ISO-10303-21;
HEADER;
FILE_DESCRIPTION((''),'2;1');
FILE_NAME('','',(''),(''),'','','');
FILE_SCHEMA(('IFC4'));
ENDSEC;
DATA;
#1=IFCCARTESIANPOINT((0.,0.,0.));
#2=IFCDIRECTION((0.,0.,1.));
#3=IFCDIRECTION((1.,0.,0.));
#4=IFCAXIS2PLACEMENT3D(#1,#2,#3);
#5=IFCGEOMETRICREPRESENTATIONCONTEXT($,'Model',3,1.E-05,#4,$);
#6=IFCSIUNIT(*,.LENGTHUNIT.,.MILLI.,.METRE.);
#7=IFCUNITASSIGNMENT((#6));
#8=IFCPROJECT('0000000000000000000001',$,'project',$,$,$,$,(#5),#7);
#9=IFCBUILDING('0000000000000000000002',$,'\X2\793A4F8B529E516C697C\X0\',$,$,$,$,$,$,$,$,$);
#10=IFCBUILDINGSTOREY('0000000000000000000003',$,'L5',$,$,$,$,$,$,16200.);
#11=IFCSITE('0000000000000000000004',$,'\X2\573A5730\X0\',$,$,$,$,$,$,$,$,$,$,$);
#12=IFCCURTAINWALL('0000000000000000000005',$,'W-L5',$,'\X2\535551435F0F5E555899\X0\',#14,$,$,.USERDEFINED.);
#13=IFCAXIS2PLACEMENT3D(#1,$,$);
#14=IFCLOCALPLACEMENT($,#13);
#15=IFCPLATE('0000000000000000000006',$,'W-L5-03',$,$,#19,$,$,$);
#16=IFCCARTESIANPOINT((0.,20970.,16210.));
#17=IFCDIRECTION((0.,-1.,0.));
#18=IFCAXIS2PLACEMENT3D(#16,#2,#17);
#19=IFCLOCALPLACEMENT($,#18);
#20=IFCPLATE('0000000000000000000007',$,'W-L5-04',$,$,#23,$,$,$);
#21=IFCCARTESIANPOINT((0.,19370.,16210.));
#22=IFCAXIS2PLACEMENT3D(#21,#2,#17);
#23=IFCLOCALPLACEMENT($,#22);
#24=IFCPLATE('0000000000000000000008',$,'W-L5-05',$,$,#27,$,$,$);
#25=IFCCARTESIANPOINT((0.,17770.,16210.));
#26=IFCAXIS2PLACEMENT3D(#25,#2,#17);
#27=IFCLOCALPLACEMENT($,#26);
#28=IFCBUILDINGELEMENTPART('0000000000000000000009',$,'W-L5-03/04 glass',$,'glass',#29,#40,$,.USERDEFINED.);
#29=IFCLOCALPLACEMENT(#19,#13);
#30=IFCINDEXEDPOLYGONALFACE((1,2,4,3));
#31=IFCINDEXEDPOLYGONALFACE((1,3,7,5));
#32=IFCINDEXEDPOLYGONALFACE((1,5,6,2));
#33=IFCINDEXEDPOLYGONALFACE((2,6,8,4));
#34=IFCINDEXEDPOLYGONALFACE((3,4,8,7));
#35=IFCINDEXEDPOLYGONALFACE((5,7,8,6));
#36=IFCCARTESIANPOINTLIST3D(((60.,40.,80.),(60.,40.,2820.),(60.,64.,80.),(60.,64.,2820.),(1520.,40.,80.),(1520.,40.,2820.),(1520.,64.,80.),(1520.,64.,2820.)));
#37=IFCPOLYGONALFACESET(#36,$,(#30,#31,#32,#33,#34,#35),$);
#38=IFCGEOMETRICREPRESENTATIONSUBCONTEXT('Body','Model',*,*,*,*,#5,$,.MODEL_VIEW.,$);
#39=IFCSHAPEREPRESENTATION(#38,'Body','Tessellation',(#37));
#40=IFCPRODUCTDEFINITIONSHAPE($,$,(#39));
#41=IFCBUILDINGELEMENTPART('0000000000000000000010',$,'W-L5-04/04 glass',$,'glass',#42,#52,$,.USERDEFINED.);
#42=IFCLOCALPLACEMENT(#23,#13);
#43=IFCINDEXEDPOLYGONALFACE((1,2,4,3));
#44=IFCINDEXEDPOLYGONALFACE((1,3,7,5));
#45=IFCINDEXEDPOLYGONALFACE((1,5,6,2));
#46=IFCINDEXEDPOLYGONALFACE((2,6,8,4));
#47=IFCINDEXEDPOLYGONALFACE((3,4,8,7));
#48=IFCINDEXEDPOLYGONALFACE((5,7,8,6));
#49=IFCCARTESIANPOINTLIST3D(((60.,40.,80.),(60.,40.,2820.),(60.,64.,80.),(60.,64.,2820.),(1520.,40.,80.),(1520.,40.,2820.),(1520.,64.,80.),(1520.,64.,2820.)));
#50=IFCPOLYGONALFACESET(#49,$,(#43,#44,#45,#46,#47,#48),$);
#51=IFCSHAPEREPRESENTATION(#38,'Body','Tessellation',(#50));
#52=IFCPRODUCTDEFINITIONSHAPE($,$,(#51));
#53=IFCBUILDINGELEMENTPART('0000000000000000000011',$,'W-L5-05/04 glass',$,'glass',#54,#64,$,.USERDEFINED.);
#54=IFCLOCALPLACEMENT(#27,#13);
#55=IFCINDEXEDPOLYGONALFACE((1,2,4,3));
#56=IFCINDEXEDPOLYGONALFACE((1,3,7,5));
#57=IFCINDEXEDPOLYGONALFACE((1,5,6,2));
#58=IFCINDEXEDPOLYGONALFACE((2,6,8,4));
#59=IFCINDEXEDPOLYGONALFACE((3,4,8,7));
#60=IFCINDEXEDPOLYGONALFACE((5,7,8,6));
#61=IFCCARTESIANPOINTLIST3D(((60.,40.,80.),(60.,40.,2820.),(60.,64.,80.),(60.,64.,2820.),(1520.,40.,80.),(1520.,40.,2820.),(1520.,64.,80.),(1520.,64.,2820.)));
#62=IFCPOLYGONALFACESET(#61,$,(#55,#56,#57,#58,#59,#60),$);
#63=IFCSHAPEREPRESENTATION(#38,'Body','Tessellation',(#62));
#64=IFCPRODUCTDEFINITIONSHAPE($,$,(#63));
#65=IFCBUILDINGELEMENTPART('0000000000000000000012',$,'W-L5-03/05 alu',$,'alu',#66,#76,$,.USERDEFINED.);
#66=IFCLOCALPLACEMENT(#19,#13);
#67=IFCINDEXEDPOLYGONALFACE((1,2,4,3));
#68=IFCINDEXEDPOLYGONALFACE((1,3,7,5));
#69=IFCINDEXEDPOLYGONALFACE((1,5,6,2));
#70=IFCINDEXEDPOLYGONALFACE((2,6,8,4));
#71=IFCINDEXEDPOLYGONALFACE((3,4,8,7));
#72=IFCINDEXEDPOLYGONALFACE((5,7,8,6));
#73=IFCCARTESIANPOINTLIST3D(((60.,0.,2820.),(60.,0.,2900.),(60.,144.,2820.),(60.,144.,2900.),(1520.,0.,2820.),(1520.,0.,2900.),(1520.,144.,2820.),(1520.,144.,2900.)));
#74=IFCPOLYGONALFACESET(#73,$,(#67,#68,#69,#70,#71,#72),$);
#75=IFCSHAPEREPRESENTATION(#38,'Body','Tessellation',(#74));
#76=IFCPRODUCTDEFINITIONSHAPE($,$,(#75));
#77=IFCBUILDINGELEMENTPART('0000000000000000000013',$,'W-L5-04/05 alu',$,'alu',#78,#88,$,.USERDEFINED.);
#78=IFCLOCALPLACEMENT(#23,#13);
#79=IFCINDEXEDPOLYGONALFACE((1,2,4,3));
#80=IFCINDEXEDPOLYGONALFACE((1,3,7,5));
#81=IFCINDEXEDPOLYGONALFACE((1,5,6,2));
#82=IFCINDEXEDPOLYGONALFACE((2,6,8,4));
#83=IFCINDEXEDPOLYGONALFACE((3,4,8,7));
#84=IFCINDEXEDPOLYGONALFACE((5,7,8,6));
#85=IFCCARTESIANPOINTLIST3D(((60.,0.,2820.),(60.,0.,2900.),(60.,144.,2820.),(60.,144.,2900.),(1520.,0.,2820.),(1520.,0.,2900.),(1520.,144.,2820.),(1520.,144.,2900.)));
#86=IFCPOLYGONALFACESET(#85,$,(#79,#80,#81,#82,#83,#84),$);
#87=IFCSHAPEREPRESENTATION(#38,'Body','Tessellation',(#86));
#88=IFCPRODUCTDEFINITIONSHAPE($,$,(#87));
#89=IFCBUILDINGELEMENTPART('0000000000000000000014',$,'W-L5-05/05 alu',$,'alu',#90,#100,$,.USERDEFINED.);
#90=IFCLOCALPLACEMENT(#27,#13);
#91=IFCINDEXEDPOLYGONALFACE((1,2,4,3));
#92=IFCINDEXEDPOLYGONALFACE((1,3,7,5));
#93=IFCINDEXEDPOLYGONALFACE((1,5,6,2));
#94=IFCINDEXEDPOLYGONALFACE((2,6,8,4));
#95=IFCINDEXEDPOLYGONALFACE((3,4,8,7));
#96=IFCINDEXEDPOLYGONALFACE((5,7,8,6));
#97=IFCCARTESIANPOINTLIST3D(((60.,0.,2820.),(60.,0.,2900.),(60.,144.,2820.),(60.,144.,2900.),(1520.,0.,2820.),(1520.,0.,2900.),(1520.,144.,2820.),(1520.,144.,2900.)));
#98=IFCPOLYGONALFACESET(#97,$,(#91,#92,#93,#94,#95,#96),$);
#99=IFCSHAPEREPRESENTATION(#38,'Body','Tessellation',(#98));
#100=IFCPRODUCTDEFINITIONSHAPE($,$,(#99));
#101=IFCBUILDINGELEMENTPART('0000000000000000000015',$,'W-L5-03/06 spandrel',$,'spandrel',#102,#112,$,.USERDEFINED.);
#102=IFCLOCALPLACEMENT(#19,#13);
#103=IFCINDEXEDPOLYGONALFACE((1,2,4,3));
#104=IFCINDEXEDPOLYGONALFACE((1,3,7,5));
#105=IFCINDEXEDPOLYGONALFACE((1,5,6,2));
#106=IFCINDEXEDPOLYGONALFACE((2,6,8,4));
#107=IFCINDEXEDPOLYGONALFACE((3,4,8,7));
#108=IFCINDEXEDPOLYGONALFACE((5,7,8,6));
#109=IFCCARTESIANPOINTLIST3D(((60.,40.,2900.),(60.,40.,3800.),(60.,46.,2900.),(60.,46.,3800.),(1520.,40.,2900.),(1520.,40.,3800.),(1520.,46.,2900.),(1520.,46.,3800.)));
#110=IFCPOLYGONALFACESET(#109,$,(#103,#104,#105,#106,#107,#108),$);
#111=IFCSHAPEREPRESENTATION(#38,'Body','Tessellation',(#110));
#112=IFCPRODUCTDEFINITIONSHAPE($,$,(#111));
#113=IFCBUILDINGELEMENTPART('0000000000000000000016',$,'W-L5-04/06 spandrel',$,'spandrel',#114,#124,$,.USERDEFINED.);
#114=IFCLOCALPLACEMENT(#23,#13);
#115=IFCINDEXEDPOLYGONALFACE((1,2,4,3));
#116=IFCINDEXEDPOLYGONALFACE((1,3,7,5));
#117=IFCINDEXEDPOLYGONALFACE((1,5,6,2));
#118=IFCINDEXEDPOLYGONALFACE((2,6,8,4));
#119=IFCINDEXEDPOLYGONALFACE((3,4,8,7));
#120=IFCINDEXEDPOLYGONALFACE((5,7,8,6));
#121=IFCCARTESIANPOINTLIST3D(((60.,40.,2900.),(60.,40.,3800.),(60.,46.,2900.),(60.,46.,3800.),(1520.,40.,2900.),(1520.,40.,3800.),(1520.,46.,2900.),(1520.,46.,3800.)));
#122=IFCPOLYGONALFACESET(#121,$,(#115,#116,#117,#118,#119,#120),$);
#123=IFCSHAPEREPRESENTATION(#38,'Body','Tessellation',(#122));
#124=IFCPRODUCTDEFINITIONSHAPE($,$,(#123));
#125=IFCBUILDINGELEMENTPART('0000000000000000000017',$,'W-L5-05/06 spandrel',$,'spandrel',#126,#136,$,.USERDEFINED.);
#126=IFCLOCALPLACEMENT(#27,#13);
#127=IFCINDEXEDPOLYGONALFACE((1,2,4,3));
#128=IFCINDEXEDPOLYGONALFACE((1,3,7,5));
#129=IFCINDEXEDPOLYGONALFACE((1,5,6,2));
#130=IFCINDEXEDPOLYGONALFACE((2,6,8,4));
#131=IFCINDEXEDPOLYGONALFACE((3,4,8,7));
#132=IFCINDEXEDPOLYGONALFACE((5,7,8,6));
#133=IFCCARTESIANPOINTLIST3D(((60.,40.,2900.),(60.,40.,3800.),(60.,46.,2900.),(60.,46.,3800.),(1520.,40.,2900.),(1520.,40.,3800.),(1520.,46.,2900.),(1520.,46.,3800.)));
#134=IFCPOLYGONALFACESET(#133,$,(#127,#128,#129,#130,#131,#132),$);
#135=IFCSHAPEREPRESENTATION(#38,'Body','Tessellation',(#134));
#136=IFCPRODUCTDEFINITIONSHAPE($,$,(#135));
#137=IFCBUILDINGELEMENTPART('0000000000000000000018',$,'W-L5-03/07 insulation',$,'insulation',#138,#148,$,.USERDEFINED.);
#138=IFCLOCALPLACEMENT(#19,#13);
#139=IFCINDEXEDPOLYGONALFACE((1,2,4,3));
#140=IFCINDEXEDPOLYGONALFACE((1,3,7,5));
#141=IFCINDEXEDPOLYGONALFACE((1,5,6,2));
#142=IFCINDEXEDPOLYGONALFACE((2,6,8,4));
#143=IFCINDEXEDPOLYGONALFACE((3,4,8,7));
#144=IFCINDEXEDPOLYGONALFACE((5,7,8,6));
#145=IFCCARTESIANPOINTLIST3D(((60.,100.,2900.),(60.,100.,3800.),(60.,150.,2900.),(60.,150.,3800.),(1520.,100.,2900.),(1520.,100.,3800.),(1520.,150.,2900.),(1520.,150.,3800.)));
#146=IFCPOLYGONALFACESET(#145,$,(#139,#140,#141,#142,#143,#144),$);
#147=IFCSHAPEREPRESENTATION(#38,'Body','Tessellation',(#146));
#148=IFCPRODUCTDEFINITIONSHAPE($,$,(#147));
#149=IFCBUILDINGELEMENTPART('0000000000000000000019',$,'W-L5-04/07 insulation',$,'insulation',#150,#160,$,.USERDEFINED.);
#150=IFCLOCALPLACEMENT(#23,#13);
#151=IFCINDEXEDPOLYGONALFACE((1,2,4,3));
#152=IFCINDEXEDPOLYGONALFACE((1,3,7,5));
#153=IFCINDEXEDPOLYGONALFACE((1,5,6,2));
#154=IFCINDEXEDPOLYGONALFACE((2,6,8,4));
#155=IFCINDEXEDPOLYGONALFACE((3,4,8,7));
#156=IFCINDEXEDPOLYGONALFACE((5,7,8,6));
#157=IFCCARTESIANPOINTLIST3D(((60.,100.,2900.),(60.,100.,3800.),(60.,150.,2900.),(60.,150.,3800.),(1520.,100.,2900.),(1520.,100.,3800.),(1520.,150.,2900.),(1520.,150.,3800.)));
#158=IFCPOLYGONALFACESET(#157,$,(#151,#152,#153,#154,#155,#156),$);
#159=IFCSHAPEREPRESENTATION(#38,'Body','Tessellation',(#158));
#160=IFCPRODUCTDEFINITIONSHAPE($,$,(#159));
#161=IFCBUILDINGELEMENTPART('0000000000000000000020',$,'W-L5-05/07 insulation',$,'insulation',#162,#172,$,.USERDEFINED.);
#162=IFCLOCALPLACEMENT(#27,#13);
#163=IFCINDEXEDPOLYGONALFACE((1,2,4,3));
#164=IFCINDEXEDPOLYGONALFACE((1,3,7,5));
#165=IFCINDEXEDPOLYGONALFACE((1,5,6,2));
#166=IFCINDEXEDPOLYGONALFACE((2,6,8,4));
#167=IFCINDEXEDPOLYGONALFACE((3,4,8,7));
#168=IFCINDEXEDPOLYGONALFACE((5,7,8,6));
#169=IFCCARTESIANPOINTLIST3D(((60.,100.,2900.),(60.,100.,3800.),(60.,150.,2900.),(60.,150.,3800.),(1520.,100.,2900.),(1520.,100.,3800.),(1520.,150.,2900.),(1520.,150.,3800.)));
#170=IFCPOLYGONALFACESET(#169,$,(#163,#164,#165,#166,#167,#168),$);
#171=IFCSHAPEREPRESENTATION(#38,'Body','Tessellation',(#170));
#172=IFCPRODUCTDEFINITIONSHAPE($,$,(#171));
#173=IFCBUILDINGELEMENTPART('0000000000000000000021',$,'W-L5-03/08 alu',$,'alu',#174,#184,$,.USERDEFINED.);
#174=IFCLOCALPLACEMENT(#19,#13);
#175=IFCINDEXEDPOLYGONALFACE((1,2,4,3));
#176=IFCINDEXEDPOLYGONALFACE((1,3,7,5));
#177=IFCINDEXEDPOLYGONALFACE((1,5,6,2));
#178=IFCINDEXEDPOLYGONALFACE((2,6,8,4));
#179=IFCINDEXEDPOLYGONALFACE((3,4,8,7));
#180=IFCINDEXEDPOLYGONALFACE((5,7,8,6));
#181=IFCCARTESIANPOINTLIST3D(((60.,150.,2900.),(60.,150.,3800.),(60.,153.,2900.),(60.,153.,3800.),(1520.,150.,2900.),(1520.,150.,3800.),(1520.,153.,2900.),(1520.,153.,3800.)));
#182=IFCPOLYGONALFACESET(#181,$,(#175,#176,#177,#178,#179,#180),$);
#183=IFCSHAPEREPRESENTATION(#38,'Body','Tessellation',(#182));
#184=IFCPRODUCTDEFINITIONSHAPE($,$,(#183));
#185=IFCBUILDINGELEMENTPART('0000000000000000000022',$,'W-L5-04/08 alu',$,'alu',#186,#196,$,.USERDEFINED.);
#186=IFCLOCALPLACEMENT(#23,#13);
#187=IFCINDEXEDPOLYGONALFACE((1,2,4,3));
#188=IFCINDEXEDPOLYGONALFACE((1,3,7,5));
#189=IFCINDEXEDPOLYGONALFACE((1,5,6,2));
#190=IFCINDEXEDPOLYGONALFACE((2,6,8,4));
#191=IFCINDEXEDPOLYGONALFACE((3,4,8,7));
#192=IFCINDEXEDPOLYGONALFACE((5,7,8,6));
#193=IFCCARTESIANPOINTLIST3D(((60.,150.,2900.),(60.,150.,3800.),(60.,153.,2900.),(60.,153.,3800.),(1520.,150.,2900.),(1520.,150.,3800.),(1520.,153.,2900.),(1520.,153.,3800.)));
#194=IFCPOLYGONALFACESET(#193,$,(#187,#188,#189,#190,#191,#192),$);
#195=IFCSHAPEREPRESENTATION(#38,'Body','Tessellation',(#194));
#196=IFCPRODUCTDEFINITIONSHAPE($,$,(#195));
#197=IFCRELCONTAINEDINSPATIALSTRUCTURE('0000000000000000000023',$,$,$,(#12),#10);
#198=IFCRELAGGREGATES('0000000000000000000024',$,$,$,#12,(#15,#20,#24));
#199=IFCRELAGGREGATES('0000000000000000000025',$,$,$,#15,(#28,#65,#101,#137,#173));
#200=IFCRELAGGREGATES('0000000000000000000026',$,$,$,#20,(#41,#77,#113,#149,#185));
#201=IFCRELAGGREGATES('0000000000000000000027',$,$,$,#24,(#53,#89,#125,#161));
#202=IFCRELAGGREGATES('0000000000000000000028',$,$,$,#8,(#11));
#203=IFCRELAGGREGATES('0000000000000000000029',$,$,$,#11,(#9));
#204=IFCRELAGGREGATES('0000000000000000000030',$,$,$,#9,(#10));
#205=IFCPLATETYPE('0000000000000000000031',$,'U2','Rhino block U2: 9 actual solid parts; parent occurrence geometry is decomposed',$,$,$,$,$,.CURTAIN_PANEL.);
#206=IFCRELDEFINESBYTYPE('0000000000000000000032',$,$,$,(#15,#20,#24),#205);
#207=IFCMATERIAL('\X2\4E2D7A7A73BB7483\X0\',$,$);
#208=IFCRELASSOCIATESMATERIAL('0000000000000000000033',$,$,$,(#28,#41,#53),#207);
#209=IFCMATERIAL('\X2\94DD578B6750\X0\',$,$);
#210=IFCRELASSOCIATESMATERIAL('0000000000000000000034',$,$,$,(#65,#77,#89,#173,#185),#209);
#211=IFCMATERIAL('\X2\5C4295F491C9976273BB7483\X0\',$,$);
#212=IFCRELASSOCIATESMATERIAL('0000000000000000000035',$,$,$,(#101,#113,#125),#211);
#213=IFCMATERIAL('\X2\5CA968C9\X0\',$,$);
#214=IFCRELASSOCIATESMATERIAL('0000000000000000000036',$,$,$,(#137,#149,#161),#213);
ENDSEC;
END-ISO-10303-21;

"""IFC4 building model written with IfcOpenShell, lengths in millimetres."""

from ifc_helpers import new_model, si_unit, frame, frame_2d, origin, origin_with_axes, place, context, subcontext, project, spatial, rectangle, extrude, source, transform, mapped, material, type_object, element, aggregate, save


model = new_model("IFC4")

# Units and contexts
model_context = context("Model", 3, precision=1e-05, world=origin_with_axes())
body_context = subcontext(model_context, "Body", "Model", "MODEL_VIEW")
ifc_project = project(units=[si_unit("LENGTHUNIT", "METRE", prefix="MILLI")], contexts=[model_context])

# Site, building, storey
site = spatial("IfcSite", under=ifc_project, Name="场地")
building = spatial("IfcBuilding", under=site, Name="示例办公楼")
storey = spatial("IfcBuildingStorey", under=building, Name="L5", Elevation=16200.0)

# Curtain wall, plates, building element parts
curtain_wall = element("IfcCurtainWall", 1, inside=storey, Name="W-L5", ObjectType="单元式幕墙", PredefinedType="USERDEFINED")
plate_type = type_object("IfcPlateType", Name="U2", Description="Rhino block U2: 9 actual solid parts; parent occurrence geometry is decomposed", PredefinedType="CURTAIN_PANEL")
plate_1_placement = place(None, frame((0.0, 20970.0, 16210.0), z_axis=(0.0, 0.0, 1.0), x_axis=(0.0, -1.0, 0.0)))
plate_1 = element("IfcPlate", 2, at=plate_1_placement, type_object=plate_type, Name="W-L5-03")
ifc_material_1 = material(Name="铝型材")
plate_2_placement = place(None, frame((0.0, 19370.0, 16210.0), z_axis=(0.0, 0.0, 1.0), x_axis=(0.0, -1.0, 0.0)))
plate_2 = element("IfcPlate", 3, at=plate_2_placement, type_object=plate_type, Name="W-L5-04")
plate_3_placement = place(None, frame((0.0, 17770.0, 16210.0), z_axis=(0.0, 0.0, 1.0), x_axis=(0.0, -1.0, 0.0)))
plate_3 = element("IfcPlate", 4, at=plate_3_placement, type_object=plate_type, Name="W-L5-05")
aggregate(curtain_wall, [plate_1, plate_2, plate_3])
ifc_material_2 = material(Name="中空玻璃")
shared_shape_1 = source(origin(), body_context, "Body", "SweptSolid", [
    extrude(rectangle(XDim=1460.0, YDim=24.0, at=frame_2d((790.0, 52.0))), frame((0.0, 0.0, 80.0)), (0.0, 0.0, 1.0), 2740.0),
])
building_element_part_1_placement = place(plate_1_placement, origin())
building_element_part_1 = element("IfcBuildingElementPart", 5, at=building_element_part_1_placement, material=ifc_material_2, Name="W-L5-03/04 glass", ObjectType="glass", PredefinedType="USERDEFINED", context=body_context, shape_type="MappedRepresentation", body=[
    mapped(shared_shape_1, transform((0.0, 0.0, 0.0))),
])
building_element_part_2_placement = place(plate_2_placement, origin())
building_element_part_2 = element("IfcBuildingElementPart", 6, at=building_element_part_2_placement, material=ifc_material_2, Name="W-L5-04/04 glass", ObjectType="glass", PredefinedType="USERDEFINED", context=body_context, shape_type="MappedRepresentation", body=[
    mapped(shared_shape_1, transform((0.0, 0.0, 0.0))),
])
building_element_part_3_placement = place(plate_3_placement, origin())
building_element_part_3 = element("IfcBuildingElementPart", 7, at=building_element_part_3_placement, material=ifc_material_2, Name="W-L5-05/04 glass", ObjectType="glass", PredefinedType="USERDEFINED", context=body_context, shape_type="MappedRepresentation", body=[
    mapped(shared_shape_1, transform((0.0, 0.0, 0.0))),
])
shared_shape_2 = source(origin(), body_context, "Body", "SweptSolid", [
    extrude(rectangle(XDim=1460.0, YDim=144.0, at=frame_2d((790.0, 72.0))), frame((0.0, 0.0, 2820.0)), (0.0, 0.0, 1.0), 80.0),
])
building_element_part_4_placement = place(plate_1_placement, origin())
building_element_part_4 = element("IfcBuildingElementPart", 8, at=building_element_part_4_placement, material=ifc_material_1, Name="W-L5-03/05 alu", ObjectType="alu", PredefinedType="USERDEFINED", context=body_context, shape_type="MappedRepresentation", body=[
    mapped(shared_shape_2, transform((0.0, 0.0, 0.0))),
])
building_element_part_5_placement = place(plate_2_placement, origin())
building_element_part_5 = element("IfcBuildingElementPart", 9, at=building_element_part_5_placement, material=ifc_material_1, Name="W-L5-04/05 alu", ObjectType="alu", PredefinedType="USERDEFINED", context=body_context, shape_type="MappedRepresentation", body=[
    mapped(shared_shape_2, transform((0.0, 0.0, 0.0))),
])
building_element_part_6_placement = place(plate_3_placement, origin())
building_element_part_6 = element("IfcBuildingElementPart", 10, at=building_element_part_6_placement, material=ifc_material_1, Name="W-L5-05/05 alu", ObjectType="alu", PredefinedType="USERDEFINED", context=body_context, shape_type="MappedRepresentation", body=[
    mapped(shared_shape_2, transform((0.0, 0.0, 0.0))),
])
ifc_material_3 = material(Name="层间釉面玻璃")
shared_shape_3 = source(origin(), body_context, "Body", "SweptSolid", [
    extrude(rectangle(XDim=1460.0, YDim=6.0, at=frame_2d((790.0, 43.0))), frame((0.0, 0.0, 2900.0)), (0.0, 0.0, 1.0), 900.0),
])
building_element_part_7_placement = place(plate_1_placement, origin())
building_element_part_7 = element("IfcBuildingElementPart", 11, at=building_element_part_7_placement, material=ifc_material_3, Name="W-L5-03/06 spandrel", ObjectType="spandrel", PredefinedType="USERDEFINED", context=body_context, shape_type="MappedRepresentation", body=[
    mapped(shared_shape_3, transform((0.0, 0.0, 0.0))),
])
building_element_part_8_placement = place(plate_2_placement, origin())
building_element_part_8 = element("IfcBuildingElementPart", 12, at=building_element_part_8_placement, material=ifc_material_3, Name="W-L5-04/06 spandrel", ObjectType="spandrel", PredefinedType="USERDEFINED", context=body_context, shape_type="MappedRepresentation", body=[
    mapped(shared_shape_3, transform((0.0, 0.0, 0.0))),
])
building_element_part_9_placement = place(plate_3_placement, origin())
building_element_part_9 = element("IfcBuildingElementPart", 13, at=building_element_part_9_placement, material=ifc_material_3, Name="W-L5-05/06 spandrel", ObjectType="spandrel", PredefinedType="USERDEFINED", context=body_context, shape_type="MappedRepresentation", body=[
    mapped(shared_shape_3, transform((0.0, 0.0, 0.0))),
])
ifc_material_4 = material(Name="岩棉")
shared_shape_4 = source(origin(), body_context, "Body", "SweptSolid", [
    extrude(rectangle(XDim=1460.0, YDim=50.0, at=frame_2d((790.0, 125.0))), frame((0.0, 0.0, 2900.0)), (0.0, 0.0, 1.0), 900.0),
])
building_element_part_10_placement = place(plate_1_placement, origin())
building_element_part_10 = element("IfcBuildingElementPart", 14, at=building_element_part_10_placement, material=ifc_material_4, Name="W-L5-03/07 insulation", ObjectType="insulation", PredefinedType="USERDEFINED", context=body_context, shape_type="MappedRepresentation", body=[
    mapped(shared_shape_4, transform((0.0, 0.0, 0.0))),
])
building_element_part_11_placement = place(plate_2_placement, origin())
building_element_part_11 = element("IfcBuildingElementPart", 15, at=building_element_part_11_placement, material=ifc_material_4, Name="W-L5-04/07 insulation", ObjectType="insulation", PredefinedType="USERDEFINED", context=body_context, shape_type="MappedRepresentation", body=[
    mapped(shared_shape_4, transform((0.0, 0.0, 0.0))),
])
building_element_part_12_placement = place(plate_3_placement, origin())
building_element_part_12 = element("IfcBuildingElementPart", 16, at=building_element_part_12_placement, material=ifc_material_4, Name="W-L5-05/07 insulation", ObjectType="insulation", PredefinedType="USERDEFINED", context=body_context, shape_type="MappedRepresentation", body=[
    mapped(shared_shape_4, transform((0.0, 0.0, 0.0))),
])
shared_shape_5 = source(origin(), body_context, "Body", "SweptSolid", [
    extrude(rectangle(XDim=1460.0, YDim=3.0, at=frame_2d((790.0, 151.5))), frame((0.0, 0.0, 2900.0)), (0.0, 0.0, 1.0), 900.0),
])
building_element_part_13_placement = place(plate_1_placement, origin())
building_element_part_13 = element("IfcBuildingElementPart", 17, at=building_element_part_13_placement, material=ifc_material_1, Name="W-L5-03/08 alu", ObjectType="alu", PredefinedType="USERDEFINED", context=body_context, shape_type="MappedRepresentation", body=[
    mapped(shared_shape_5, transform((0.0, 0.0, 0.0))),
])
aggregate(plate_1, [building_element_part_1, building_element_part_4, building_element_part_7, building_element_part_10, building_element_part_13])
building_element_part_14_placement = place(plate_2_placement, origin())
building_element_part_14 = element("IfcBuildingElementPart", 18, at=building_element_part_14_placement, material=ifc_material_1, Name="W-L5-04/08 alu", ObjectType="alu", PredefinedType="USERDEFINED", context=body_context, shape_type="MappedRepresentation", body=[
    mapped(shared_shape_5, transform((0.0, 0.0, 0.0))),
])
aggregate(plate_2, [building_element_part_2, building_element_part_5, building_element_part_8, building_element_part_11, building_element_part_14])
aggregate(plate_3, [building_element_part_3, building_element_part_6, building_element_part_9, building_element_part_12])

save(model, "model.ifc")
